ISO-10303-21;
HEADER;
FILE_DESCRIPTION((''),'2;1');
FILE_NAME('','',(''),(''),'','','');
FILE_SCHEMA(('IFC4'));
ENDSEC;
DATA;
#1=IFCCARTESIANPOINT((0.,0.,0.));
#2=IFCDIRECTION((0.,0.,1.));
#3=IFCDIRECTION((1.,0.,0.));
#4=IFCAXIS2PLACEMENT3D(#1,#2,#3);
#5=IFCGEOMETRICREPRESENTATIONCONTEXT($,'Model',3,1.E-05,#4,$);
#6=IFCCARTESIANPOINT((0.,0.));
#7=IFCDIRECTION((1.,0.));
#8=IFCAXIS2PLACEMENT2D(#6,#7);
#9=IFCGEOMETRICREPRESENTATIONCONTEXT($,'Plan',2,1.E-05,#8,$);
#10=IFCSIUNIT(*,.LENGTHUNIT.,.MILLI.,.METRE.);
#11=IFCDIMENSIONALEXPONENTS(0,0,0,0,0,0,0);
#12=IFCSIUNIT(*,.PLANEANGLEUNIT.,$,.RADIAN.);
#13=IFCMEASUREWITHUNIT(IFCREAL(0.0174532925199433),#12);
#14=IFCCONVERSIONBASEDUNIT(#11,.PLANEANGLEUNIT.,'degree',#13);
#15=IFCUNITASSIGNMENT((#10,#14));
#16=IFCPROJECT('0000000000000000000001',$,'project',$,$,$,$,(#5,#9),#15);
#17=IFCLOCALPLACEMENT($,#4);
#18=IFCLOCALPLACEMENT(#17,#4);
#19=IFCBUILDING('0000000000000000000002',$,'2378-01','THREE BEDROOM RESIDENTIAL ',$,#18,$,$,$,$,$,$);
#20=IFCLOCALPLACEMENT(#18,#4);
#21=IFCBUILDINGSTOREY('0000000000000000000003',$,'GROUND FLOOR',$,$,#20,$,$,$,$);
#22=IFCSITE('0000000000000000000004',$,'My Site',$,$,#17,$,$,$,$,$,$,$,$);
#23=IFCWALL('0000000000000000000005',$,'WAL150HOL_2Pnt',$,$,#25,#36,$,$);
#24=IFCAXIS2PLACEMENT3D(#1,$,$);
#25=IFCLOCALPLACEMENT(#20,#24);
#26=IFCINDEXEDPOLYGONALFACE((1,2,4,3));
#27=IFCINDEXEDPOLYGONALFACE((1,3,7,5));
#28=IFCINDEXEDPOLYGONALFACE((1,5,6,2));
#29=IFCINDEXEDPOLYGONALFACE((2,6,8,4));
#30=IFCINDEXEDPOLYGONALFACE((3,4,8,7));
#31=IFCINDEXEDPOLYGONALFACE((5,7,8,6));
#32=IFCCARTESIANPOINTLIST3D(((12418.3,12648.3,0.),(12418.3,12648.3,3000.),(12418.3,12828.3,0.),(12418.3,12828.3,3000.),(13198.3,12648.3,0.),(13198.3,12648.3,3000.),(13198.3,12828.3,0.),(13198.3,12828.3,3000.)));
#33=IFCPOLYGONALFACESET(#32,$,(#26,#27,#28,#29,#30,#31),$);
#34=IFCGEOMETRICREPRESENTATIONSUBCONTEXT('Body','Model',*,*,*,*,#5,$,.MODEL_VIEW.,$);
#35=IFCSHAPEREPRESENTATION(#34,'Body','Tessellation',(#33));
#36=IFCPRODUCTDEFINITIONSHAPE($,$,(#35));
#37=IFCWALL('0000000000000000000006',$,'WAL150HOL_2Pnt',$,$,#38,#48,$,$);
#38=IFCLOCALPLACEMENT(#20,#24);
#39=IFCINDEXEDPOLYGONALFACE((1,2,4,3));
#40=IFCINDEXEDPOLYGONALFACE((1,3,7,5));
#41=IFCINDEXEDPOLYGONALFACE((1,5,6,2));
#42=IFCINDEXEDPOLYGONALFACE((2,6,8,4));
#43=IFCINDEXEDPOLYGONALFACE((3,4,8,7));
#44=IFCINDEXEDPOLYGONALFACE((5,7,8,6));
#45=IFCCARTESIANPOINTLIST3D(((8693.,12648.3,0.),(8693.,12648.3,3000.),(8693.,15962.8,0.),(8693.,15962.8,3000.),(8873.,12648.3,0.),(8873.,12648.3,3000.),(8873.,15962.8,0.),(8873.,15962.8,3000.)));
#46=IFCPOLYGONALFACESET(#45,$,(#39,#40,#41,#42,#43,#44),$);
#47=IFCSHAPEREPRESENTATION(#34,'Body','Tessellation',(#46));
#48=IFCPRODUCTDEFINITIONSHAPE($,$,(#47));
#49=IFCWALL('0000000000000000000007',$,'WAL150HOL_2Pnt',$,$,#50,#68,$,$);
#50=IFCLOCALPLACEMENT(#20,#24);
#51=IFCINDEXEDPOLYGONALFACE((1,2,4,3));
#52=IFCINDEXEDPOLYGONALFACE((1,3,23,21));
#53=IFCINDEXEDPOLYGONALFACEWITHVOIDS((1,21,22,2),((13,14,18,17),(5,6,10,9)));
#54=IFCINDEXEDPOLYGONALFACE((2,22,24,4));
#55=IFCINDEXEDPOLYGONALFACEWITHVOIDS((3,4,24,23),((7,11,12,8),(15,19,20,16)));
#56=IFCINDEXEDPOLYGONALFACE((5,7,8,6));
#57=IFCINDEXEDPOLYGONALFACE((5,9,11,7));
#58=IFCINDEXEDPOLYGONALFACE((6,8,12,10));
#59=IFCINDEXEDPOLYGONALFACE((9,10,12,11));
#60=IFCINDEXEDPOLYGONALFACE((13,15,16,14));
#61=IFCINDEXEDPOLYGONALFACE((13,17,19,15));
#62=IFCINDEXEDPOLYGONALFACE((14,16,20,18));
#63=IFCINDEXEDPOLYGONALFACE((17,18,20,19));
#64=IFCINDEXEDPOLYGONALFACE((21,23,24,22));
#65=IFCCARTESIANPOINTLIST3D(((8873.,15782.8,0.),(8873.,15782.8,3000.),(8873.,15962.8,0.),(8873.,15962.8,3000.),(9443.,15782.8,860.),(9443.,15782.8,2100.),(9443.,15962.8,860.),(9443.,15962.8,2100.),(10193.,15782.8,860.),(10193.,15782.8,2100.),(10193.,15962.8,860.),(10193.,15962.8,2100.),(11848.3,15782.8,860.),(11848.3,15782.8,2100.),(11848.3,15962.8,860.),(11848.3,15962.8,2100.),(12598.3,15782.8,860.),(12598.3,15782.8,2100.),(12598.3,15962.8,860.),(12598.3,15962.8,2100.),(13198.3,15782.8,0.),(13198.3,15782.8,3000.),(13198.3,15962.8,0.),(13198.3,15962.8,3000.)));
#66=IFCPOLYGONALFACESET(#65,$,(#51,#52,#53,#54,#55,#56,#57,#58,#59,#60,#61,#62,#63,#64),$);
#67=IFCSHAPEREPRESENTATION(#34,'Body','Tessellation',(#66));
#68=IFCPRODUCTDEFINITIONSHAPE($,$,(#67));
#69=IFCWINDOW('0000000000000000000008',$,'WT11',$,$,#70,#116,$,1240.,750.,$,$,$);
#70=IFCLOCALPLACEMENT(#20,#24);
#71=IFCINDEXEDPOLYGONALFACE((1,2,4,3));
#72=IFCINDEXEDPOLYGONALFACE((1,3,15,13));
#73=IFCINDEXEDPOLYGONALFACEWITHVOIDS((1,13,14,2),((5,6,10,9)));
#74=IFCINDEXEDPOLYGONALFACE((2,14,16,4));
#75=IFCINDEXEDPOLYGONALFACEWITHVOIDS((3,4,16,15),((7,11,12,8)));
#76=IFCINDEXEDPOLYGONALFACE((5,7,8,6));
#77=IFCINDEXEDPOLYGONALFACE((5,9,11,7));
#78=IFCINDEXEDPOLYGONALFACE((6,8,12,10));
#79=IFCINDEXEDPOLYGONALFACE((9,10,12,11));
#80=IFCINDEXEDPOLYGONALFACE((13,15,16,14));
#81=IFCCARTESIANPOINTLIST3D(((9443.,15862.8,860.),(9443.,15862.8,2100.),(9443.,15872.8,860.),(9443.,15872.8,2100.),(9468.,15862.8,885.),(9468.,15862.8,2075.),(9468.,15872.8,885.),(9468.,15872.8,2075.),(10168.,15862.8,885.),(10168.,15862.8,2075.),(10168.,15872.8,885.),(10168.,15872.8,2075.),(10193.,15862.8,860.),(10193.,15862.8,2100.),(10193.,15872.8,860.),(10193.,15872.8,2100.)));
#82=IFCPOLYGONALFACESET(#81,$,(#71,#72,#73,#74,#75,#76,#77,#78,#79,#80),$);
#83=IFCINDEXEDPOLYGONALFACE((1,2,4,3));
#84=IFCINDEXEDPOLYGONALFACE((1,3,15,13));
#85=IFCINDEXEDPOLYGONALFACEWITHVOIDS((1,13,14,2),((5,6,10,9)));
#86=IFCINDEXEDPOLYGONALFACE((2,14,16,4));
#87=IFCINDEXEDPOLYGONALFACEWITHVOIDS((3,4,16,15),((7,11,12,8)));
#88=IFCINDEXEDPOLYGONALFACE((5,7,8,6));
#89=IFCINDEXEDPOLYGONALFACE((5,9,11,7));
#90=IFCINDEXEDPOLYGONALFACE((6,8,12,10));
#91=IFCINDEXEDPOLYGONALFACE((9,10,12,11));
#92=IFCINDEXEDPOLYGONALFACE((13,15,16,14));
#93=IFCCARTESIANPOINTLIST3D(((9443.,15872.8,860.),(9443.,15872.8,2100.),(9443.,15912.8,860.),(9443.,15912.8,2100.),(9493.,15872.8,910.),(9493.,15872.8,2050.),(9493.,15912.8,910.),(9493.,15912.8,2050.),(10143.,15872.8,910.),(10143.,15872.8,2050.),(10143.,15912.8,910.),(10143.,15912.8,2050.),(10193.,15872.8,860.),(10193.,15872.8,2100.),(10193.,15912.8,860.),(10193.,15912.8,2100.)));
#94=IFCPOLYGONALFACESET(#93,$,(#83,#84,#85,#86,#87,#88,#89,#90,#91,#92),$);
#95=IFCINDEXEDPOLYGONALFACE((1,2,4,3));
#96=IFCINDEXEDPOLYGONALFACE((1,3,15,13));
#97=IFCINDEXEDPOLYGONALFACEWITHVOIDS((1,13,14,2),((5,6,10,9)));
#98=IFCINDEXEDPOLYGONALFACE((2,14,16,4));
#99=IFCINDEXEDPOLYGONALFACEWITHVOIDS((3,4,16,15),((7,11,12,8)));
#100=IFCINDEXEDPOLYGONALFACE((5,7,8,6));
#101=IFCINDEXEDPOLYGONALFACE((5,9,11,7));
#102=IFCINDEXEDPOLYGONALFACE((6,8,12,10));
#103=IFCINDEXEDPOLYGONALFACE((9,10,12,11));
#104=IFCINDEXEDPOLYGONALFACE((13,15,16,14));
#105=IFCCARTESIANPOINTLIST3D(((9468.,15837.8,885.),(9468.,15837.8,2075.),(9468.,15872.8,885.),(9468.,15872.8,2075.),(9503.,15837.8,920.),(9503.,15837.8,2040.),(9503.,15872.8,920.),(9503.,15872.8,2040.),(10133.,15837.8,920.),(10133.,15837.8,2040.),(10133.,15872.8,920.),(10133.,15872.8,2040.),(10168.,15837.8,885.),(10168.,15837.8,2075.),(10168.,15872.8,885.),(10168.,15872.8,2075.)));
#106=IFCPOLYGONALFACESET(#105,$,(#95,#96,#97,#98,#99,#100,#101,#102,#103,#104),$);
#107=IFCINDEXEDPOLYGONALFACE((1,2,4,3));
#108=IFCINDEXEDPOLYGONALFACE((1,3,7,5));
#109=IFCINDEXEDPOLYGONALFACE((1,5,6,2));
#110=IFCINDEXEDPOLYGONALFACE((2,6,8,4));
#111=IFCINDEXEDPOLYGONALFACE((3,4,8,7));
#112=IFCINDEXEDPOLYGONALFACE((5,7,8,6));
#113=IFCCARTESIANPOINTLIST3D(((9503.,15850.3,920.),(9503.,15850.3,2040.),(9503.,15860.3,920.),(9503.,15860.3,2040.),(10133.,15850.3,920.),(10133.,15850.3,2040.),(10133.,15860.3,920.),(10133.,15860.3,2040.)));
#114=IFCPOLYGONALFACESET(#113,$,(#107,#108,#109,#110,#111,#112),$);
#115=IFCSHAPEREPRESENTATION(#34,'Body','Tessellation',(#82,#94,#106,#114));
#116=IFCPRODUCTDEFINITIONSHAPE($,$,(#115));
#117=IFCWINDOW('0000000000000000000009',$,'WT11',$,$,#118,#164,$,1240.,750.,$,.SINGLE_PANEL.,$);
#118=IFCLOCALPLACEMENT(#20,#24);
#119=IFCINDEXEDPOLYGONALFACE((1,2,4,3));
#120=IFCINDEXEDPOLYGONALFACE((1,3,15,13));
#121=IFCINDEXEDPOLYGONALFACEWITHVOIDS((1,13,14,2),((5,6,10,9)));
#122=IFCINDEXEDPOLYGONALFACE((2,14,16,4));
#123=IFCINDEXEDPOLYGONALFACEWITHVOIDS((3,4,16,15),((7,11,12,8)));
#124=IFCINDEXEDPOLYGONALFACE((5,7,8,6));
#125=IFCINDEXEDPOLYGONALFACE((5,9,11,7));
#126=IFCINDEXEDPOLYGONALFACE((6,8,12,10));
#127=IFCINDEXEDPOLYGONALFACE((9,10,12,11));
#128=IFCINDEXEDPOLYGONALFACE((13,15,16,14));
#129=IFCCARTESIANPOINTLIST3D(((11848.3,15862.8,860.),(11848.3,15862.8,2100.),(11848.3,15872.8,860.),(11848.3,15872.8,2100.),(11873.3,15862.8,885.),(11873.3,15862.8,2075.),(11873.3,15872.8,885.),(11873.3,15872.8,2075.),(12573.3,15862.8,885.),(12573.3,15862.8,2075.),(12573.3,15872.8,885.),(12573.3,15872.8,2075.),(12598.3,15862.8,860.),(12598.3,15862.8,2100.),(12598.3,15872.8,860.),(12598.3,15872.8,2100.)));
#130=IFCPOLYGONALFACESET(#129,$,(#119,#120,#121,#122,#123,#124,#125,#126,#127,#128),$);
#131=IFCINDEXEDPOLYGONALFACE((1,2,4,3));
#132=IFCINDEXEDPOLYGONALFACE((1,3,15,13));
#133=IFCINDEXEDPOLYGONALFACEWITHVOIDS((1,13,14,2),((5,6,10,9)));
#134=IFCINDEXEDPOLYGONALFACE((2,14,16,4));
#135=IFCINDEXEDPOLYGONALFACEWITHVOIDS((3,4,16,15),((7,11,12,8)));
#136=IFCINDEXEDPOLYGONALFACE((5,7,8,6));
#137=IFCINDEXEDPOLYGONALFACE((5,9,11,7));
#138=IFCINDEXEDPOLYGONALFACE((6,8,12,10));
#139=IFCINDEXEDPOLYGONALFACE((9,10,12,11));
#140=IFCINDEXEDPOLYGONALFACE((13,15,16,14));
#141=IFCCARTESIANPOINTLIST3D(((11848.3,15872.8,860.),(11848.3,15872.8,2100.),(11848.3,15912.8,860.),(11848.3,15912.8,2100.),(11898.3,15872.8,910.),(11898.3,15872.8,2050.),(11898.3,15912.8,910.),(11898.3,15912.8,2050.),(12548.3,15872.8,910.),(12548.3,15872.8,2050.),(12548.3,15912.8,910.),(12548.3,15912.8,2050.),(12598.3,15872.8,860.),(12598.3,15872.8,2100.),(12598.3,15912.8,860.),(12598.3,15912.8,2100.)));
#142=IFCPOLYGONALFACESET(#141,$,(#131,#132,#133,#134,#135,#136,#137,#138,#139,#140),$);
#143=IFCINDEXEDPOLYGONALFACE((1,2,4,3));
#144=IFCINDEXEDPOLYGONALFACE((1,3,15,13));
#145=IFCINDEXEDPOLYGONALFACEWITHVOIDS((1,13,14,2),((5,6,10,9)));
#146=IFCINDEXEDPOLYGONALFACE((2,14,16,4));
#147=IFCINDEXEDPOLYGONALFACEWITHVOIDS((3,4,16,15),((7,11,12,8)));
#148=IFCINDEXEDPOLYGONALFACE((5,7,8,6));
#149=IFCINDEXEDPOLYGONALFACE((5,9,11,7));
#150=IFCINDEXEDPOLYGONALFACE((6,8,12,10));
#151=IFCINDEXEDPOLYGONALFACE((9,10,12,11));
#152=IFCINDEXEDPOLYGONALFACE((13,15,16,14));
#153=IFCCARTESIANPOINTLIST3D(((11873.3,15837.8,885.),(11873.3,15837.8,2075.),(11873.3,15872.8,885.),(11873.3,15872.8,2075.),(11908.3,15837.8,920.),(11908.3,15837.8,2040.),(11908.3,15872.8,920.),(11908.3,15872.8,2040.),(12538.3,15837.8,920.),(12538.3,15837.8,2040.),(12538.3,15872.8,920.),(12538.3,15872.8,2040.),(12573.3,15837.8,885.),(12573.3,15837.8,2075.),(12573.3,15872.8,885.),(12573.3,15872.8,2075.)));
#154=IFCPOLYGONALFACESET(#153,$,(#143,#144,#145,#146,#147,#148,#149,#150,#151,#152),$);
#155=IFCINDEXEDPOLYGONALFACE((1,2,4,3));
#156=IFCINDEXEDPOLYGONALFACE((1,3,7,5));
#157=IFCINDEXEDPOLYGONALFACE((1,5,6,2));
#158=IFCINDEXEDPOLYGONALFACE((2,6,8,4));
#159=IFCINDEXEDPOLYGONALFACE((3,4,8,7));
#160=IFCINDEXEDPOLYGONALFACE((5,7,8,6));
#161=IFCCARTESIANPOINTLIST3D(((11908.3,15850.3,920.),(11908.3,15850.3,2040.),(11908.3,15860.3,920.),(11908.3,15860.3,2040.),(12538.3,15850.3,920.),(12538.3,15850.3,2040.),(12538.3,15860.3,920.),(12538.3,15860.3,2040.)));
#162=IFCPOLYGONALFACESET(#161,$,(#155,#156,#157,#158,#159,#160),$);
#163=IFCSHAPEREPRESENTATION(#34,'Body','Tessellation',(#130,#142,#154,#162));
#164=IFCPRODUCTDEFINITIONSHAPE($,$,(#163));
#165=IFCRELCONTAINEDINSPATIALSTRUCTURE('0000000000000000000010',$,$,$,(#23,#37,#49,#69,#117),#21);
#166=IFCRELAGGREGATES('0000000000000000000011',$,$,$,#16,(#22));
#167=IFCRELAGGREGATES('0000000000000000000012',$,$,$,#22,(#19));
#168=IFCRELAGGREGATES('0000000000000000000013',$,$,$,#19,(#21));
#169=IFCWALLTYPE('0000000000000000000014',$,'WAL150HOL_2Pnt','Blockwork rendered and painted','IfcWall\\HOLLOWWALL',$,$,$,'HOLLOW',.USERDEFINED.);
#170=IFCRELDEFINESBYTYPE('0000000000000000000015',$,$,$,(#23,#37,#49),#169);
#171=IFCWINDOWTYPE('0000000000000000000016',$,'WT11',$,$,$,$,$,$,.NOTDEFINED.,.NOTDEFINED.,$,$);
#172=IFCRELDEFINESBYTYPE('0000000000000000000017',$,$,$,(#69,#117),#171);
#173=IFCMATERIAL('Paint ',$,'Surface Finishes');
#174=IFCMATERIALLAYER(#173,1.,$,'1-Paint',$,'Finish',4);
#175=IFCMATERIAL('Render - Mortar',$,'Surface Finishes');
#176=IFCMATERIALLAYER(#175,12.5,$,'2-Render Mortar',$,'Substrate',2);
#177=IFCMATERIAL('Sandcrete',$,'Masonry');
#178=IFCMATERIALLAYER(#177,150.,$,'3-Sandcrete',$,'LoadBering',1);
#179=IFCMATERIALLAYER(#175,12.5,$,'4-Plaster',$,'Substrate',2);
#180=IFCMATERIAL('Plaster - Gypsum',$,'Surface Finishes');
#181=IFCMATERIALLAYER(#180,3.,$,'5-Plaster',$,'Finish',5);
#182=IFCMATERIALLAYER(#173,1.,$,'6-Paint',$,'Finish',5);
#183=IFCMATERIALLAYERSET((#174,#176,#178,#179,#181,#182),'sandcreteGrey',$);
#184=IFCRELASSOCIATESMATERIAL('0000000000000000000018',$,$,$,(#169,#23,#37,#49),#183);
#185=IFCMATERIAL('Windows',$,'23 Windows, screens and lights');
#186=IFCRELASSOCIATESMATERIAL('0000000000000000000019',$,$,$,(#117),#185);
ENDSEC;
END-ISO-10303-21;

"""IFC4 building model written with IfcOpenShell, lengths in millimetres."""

from ifc_helpers import new_model, entity, si_unit, converted_unit, frame, origin_with_axes, origin_2d_with_axis, place, context, subcontext, project, spatial, line, indexed_curve, outline, extrude, shape, source, transform, mapped, material, layer, layer_set, layer_usage, type_object, type_shapes, element, fill, save


model = new_model("IFC4")

# Units and contexts
model_context = context("Model", 3, precision=1e-05, world=origin_with_axes())
plan_context = context("Plan", 2, precision=1e-05, world=origin_2d_with_axis())
body_context_1 = subcontext(model_context, "Body", "Model", "MODEL_VIEW")
body_context_2 = subcontext(plan_context, "Body", "Plan", "PLAN_VIEW")
ifc_project = project(units=[si_unit("LENGTHUNIT", "METRE", prefix="MILLI"), converted_unit("PLANEANGLEUNIT", "degree", entity("IfcReal", 0.0174532925199433), si_unit("PLANEANGLEUNIT", "RADIAN"), dimensions=[0, 0, 0, 0, 0, 0, 0])], contexts=[model_context, plan_context])

# Site, building, storey
site_placement = place(None, origin_with_axes())
site = spatial("IfcSite", under=ifc_project, at=site_placement, Name="My Site")
building_placement = place(site_placement, origin_with_axes())
building = spatial("IfcBuilding", under=site, at=building_placement, Name="2378-01", Description="THREE BEDROOM RESIDENTIAL ")
storey_placement = place(building_placement, origin_with_axes())
storey = spatial("IfcBuildingStorey", under=building, at=storey_placement, Name="GROUND FLOOR")

# Walls
ifc_material_1 = material(Name="Paint ", Category="Surface Finishes")
ifc_layer_1 = layer(ifc_material_1, 1.0, Name="1-Paint", Category="Finish", Priority=4)
ifc_material_2 = material(Name="Render - Mortar", Category="Surface Finishes")
ifc_layer_2 = layer(ifc_material_2, 12.5, Name="2-Render Mortar", Category="Substrate", Priority=2)
ifc_material_3 = material(Name="Sandcrete", Category="Masonry")
ifc_layer_3 = layer(ifc_material_3, 150.0, Name="3-Sandcrete", Category="LoadBering", Priority=1)
ifc_layer_4 = layer(ifc_material_2, 12.5, Name="4-Plaster", Category="Substrate", Priority=2)
ifc_material_4 = material(Name="Plaster - Gypsum", Category="Surface Finishes")
ifc_layer_5 = layer(ifc_material_4, 3.0, Name="5-Plaster", Category="Finish", Priority=5)
ifc_layer_6 = layer(ifc_material_1, 1.0, Name="6-Paint", Category="Finish", Priority=5)
ifc_layer_set_1 = layer_set([ifc_layer_1, ifc_layer_2, ifc_layer_3, ifc_layer_4, ifc_layer_5, ifc_layer_6], Name="sandcreteGrey")
ifc_layer_usage_1 = layer_usage(ifc_layer_set_1, "AXIS2", "POSITIVE", 0.0)
wall_type_1 = type_object("IfcWallType", Name="WAL150HOL_2Pnt", Description="Blockwork rendered and painted", ApplicableOccurrence="IfcWall\\HOLLOWWALL", ElementType="HOLLOW", PredefinedType="USERDEFINED", material=ifc_layer_set_1)
wall_1_placement = place(storey_placement, frame((13198.3, 12828.3, 0.0), z_axis=(0.0, 0.0, 1.0), x_axis=(-1.0, 0.000001, 0.0)))
element("IfcWall", 1, at=wall_1_placement, inside=storey, type_object=wall_type_1, material=ifc_layer_usage_1, Name="WAL150HOL_2Pnt", context=body_context_1, shape_type="SweptSolid", body=[
    extrude(outline(indexed_curve([(0.0, 0.0), (0.0, 180.0), (780.0, 180.0), (780.0, 0.0), (0.0, 0.0)], self_intersect=False)), origin_with_axes(), (0.0, 0.0, 1.0), 3000.0),
])
ifc_layer_usage_2 = layer_usage(ifc_layer_set_1, "AXIS2", "POSITIVE", 0.0)
wall_2_placement = place(storey_placement, frame((8693.0, 15962.8, 0.0), z_axis=(0.0, 0.0, 1.0), x_axis=(-0.000001, -1.0, 0.0)))
element("IfcWall", 2, at=wall_2_placement, inside=storey, type_object=wall_type_1, material=ifc_layer_usage_2, Name="WAL150HOL_2Pnt", context=body_context_1, shape_type="SweptSolid", body=[
    extrude(outline(indexed_curve([(0.0, 0.0), (0.0, 180.0), (3314.5, 180.0), (3314.5, 0.0), (0.0, 0.0)], self_intersect=False)), origin_with_axes(), (0.0, 0.0, 1.0), 3000.0),
])

# Wall, openings, windows
ifc_layer_usage_3 = layer_usage(ifc_layer_set_1, "AXIS2", "POSITIVE", 0.0)
wall_3_placement = place(storey_placement, frame((13198.3, 15962.8, 0.0), z_axis=(0.0, 0.0, 1.0), x_axis=(-1.0, 0.000001, 0.0)))
wall_3 = element("IfcWall", 3, at=wall_3_placement, inside=storey, type_object=wall_type_1, material=ifc_layer_usage_3, Name="WAL150HOL_2Pnt", context=body_context_1, shape_type="SweptSolid", body=[
    extrude(outline(indexed_curve([(0.0, 0.0), (0.0, 180.0), (4325.3, 180.0), (4325.3, 0.0), (0.0, 0.0)], self_intersect=False)), origin_with_axes(), (0.0, 0.0, 1.0), 3000.0),
])
shared_shape_1 = source(origin_with_axes(), body_context_1, "Body", "SweptSolid", [
    extrude(outline(indexed_curve([(0.0, 0.0), (750.0, 0.0), (750.0, 1240.0), (0.0, 1240.0)], segments=[line(1, 2, 3, 4, 1)])), frame((0.0, -100.0, 0.0), z_axis=(0.0, -1.0, 0.0), x_axis=(1.0, 0.0, 0.0)), (0.0, 0.0, -1.0), 380.0),
])
opening_1_placement = place(wall_3_placement, frame((3005.3, 0.0, 860.0), z_axis=(0.0, 0.0, 1.0), x_axis=(1.0, 0.0, 0.0)))
opening_1 = element("IfcOpeningElement", 4, at=opening_1_placement, cuts=wall_3, PredefinedType="OPENING", context=body_context_1, shape_type="MappedRepresentation", body=[
    mapped(shared_shape_1, transform((0.0, 0.0, 0.0), x_axis=(1.0, 0.0, 0.0), y_axis=(0.0, 1.0, 0.0), z_axis=(0.0, 0.0, 1.0), scale=1.0)),
])
opening_2_placement = place(wall_3_placement, frame((600.0, 0.0, 860.0), z_axis=(0.0, 0.0, 1.0), x_axis=(1.0, 0.0, 0.0)))
opening_2 = element("IfcOpeningElement", 5, at=opening_2_placement, cuts=wall_3, PredefinedType="OPENING", context=body_context_1, shape_type="MappedRepresentation", body=[
    mapped(shared_shape_1, transform((0.0, 0.0, 0.0), x_axis=(1.0, 0.0, 0.0), y_axis=(0.0, 1.0, 0.0), z_axis=(0.0, 0.0, 1.0), scale=1.0)),
])
window_type_1 = type_object("IfcWindowType", Name="WT11", PartitioningType="NOTDEFINED", PredefinedType="NOTDEFINED")
shared_shape_2 = source(origin_with_axes(), body_context_1, "Body", "SweptSolid", [
    extrude(outline(indexed_curve([(0.0, 0.0), (750.0, 0.0), (750.0, 1240.0), (0.0, 1240.0)], segments=[line(1, 2, 3, 4, 1)]), holes=[indexed_curve([(25.0, 25.0), (725.0, 25.0), (725.0, 1215.0), (25.0, 1215.0)], segments=[line(1, 2, 3, 4, 1)])]), frame((0.0, 90.0, 0.0), z_axis=(0.0, -1.0, 0.0), x_axis=(1.0, 0.0, 0.0)), (0.0, 0.0, -1.0), 10.0),
    extrude(outline(indexed_curve([(0.0, 0.0), (750.0, 0.0), (750.0, 1240.0), (0.0, 1240.0)], segments=[line(1, 2, 3, 4, 1)]), holes=[indexed_curve([(50.0, 50.0), (700.0, 50.0), (700.0, 1190.0), (50.0, 1190.0)], segments=[line(1, 2, 3, 4, 1)])]), frame((0.0, 50.0, 0.0), z_axis=(0.0, -1.0, 0.0), x_axis=(1.0, 0.0, 0.0)), (0.0, 0.0, -1.0), 40.0),
    extrude(outline(indexed_curve([(0.0, 0.0), (700.0, 0.0), (700.0, 1190.0), (0.0, 1190.0)], segments=[line(1, 2, 3, 4, 1)]), holes=[indexed_curve([(35.0, 35.0), (665.0, 35.0), (665.0, 1155.0), (35.0, 1155.0)], segments=[line(1, 2, 3, 4, 1)])]), frame((25.0, 90.0, 25.0), z_axis=(0.0, -1.0, 0.0), x_axis=(1.0, 0.0, 0.0)), (0.0, 0.0, -1.0), 35.0),
    extrude(outline(indexed_curve([(35.0, 35.0), (665.0, 35.0), (665.0, 1155.0), (35.0, 1155.0)], segments=[line(1, 2, 3, 4, 1)])), frame((25.0, 102.5, 25.0), z_axis=(0.0, -1.0, 0.0), x_axis=(1.0, 0.0, 0.0)), (0.0, 0.0, -1.0), 10.0),
])
shared_shape_3 = source(origin_with_axes(), body_context_2, "Body", "Curve2D", [
    entity("IfcIndexedPolyCurve", entity("IfcCartesianPointList2D", [[50.0, 50.0], [700.0, 50.0]])),
    entity("IfcIndexedPolyCurve", entity("IfcCartesianPointList2D", [[0.0, 100.0], [25.0, 100.0], [25.0, 90.0], [50.0, 90.0], [50.0, 50.0], [0.0, 50.0]]), [entity("IfcLineIndex", [1, 2, 3, 4, 5, 6, 1])]),
    entity("IfcIndexedPolyCurve", entity("IfcCartesianPointList2D", [[750.0, 100.0], [725.0, 100.0], [725.0, 90.0], [700.0, 90.0], [700.0, 50.0], [750.0, 50.0]]), [entity("IfcLineIndex", [1, 2, 3, 4, 5, 6, 1])]),
    entity("IfcIndexedPolyCurve", entity("IfcCartesianPointList2D", [[25.0, 90.0], [60.0, 90.0], [60.0, 125.0], [25.0, 125.0]]), [entity("IfcLineIndex", [1, 2, 3, 4, 1])]),
    entity("IfcIndexedPolyCurve", entity("IfcCartesianPointList2D", [[725.0, 90.0], [690.0, 90.0], [690.0, 125.0], [725.0, 125.0]]), [entity("IfcLineIndex", [1, 2, 3, 4, 1])]),
    entity("IfcIndexedPolyCurve", entity("IfcCartesianPointList2D", [[60.0, 90.0], [690.0, 90.0]])),
    entity("IfcIndexedPolyCurve", entity("IfcCartesianPointList2D", [[60.0, 125.0], [690.0, 125.0]])),
    entity("IfcIndexedPolyCurve", entity("IfcCartesianPointList2D", [[60.0, 107.5], [690.0, 107.5]])),
])
type_shapes(window_type_1, [shared_shape_2, shared_shape_3])
window_1_placement = place(opening_1_placement, frame((0.0, 0.0, 0.0), z_axis=(0.0, 0.0, 1.0), x_axis=(1.0, 0.0, 0.0)))
window_1 = element("IfcWindow", 6, at=window_1_placement, inside=storey, type_object=window_type_1, Name="WT11", OverallHeight=1240.0, OverallWidth=750.0, shapes=[
    shape(body_context_1, "Body", "MappedRepresentation", [mapped(shared_shape_2, transform((0.0, 0.0, 0.0), x_axis=(1.0, 0.0, 0.0), y_axis=(0.0, 1.0, 0.0), z_axis=(0.0, 0.0, 1.0), scale=1.0))]),
    shape(body_context_2, "Body", "MappedRepresentation", [mapped(shared_shape_3, transform((0.0, 0.0, 0.0), x_axis=(1.0, 0.0, 0.0), y_axis=(0.0, 1.0, 0.0), z_axis=(0.0, 0.0, 1.0), scale=1.0))]),
])
fill(opening_1, window_1)
ifc_material_5 = material(Name="Windows", Category="23 Windows, screens and lights")
window_2_placement = place(opening_2_placement, frame((0.0, 0.0, 0.0), z_axis=(0.0, 0.0, 1.0), x_axis=(1.0, 0.0, 0.0)))
window_2 = element("IfcWindow", 7, at=window_2_placement, inside=storey, type_object=window_type_1, material=ifc_material_5, Name="WT11", OverallHeight=1240.0, OverallWidth=750.0, PartitioningType="SINGLE_PANEL", shapes=[
    shape(body_context_1, "Body", "MappedRepresentation", [mapped(shared_shape_2, transform((0.0, 0.0, 0.0), x_axis=(1.0, 0.0, 0.0), y_axis=(0.0, 1.0, 0.0), z_axis=(0.0, 0.0, 1.0), scale=1.0))]),
    shape(body_context_2, "Body", "MappedRepresentation", [mapped(shared_shape_3, transform((0.0, 0.0, 0.0), x_axis=(1.0, 0.0, 0.0), y_axis=(0.0, 1.0, 0.0), z_axis=(0.0, 0.0, 1.0), scale=1.0))]),
])
fill(opening_2, window_2)

save(model, "model.ifc")
